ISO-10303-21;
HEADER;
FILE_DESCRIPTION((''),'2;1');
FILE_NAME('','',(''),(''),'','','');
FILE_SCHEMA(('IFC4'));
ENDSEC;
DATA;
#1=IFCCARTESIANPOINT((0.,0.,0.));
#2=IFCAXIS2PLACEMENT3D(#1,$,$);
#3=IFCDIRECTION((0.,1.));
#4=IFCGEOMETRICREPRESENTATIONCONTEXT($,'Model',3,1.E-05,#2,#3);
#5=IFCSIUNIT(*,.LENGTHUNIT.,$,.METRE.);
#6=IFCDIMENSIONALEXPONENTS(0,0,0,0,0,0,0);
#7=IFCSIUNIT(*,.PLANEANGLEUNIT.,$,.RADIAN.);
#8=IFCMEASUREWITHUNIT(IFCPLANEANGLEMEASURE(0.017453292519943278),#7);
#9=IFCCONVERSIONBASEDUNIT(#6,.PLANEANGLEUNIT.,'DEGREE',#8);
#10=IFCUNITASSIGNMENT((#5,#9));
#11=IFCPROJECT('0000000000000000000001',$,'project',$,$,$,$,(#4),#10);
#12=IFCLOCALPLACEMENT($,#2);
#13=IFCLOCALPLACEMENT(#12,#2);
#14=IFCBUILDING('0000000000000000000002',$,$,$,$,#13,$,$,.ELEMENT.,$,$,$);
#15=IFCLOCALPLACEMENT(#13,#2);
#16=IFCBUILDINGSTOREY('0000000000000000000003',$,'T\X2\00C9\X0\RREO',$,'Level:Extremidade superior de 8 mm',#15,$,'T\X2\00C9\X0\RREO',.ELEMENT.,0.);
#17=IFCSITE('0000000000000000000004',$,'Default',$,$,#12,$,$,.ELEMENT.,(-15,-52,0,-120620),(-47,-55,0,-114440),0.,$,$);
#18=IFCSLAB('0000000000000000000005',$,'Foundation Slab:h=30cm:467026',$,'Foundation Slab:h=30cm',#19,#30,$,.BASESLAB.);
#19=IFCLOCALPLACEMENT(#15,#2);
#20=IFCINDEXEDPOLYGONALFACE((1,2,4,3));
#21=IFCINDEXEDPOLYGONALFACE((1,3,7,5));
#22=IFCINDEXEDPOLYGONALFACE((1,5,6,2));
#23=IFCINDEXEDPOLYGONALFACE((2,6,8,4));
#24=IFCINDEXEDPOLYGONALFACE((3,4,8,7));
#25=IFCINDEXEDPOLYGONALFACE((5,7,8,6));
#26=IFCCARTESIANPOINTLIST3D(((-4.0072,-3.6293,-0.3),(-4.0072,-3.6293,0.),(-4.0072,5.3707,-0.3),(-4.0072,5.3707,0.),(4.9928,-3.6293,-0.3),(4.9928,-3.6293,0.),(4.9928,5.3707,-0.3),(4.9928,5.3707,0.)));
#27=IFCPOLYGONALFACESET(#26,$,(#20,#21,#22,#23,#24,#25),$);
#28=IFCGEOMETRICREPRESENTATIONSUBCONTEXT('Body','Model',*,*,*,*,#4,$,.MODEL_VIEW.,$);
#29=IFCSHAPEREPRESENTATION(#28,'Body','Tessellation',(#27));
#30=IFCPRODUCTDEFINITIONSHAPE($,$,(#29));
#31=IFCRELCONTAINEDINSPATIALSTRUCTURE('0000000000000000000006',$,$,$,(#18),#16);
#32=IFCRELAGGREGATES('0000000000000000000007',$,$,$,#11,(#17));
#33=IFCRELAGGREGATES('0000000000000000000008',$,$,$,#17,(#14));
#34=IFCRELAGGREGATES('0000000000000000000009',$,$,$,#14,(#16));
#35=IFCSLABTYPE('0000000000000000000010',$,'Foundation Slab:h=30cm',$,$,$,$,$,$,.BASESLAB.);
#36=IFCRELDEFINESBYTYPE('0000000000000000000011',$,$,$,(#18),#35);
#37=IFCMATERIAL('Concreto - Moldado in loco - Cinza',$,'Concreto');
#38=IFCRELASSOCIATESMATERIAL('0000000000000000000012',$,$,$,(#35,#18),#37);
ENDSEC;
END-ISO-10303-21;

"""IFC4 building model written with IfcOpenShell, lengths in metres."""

from ifc_helpers import new_model, entity, si_unit, converted_unit, direction, frame, origin, place, context, subcontext, project, spatial, indexed_curve, outline, extrude, material, type_object, element, save


model = new_model("IFC4")

# Units and contexts
model_context = context("Model", 3, precision=1e-05, world=origin(), true_north=direction((0.0, 1.0)))
body_context = subcontext(model_context, "Body", "Model", "MODEL_VIEW")
ifc_project = project(units=[si_unit("LENGTHUNIT", "METRE"), converted_unit("PLANEANGLEUNIT", "DEGREE", entity("IfcPlaneAngleMeasure", 0.017453292519943278), si_unit("PLANEANGLEUNIT", "RADIAN"), dimensions=[0, 0, 0, 0, 0, 0, 0])], contexts=[model_context])

# Site, building, storey
site_placement = place(None, origin())
site = spatial("IfcSite", under=ifc_project, at=site_placement, Name="Default", CompositionType="ELEMENT", RefLatitude=(-15, -52, 0, -120620), RefLongitude=(-47, -55, 0, -114440), RefElevation=0.0)
building_placement = place(site_placement, origin())
building = spatial("IfcBuilding", under=site, at=building_placement, CompositionType="ELEMENT")
storey_placement = place(building_placement, origin())
storey = spatial("IfcBuildingStorey", under=building, at=storey_placement, Name="TÉRREO", ObjectType="Level:Extremidade superior de 8 mm", LongName="TÉRREO", CompositionType="ELEMENT", Elevation=0.0)

# Slab
ifc_material = material(Name="Concreto - Moldado in loco - Cinza", Category="Concreto")
slab_type = type_object("IfcSlabType", Name="Foundation Slab:h=30cm", PredefinedType="BASESLAB", material=ifc_material)
slab_placement = place(storey_placement, origin())
element("IfcSlab", 1, at=slab_placement, inside=storey, type_object=slab_type, material=ifc_material, Name="Foundation Slab:h=30cm:467026", ObjectType="Foundation Slab:h=30cm", PredefinedType="BASESLAB", context=body_context, shape_type="SweptSolid", body=[
    extrude(outline(indexed_curve([(-4.5, -4.5), (4.5, -4.5), (4.5, 4.5), (-4.5, 4.5), (-4.5, -4.5)], self_intersect=False)), frame((0.4928, 0.8707, 0.0), z_axis=(0.0, 0.0, -1.0), x_axis=(0.0, 1.0, 0.0)), (0.0, 0.0, 1.0), 0.3),
])

save(model, "model.ifc")
